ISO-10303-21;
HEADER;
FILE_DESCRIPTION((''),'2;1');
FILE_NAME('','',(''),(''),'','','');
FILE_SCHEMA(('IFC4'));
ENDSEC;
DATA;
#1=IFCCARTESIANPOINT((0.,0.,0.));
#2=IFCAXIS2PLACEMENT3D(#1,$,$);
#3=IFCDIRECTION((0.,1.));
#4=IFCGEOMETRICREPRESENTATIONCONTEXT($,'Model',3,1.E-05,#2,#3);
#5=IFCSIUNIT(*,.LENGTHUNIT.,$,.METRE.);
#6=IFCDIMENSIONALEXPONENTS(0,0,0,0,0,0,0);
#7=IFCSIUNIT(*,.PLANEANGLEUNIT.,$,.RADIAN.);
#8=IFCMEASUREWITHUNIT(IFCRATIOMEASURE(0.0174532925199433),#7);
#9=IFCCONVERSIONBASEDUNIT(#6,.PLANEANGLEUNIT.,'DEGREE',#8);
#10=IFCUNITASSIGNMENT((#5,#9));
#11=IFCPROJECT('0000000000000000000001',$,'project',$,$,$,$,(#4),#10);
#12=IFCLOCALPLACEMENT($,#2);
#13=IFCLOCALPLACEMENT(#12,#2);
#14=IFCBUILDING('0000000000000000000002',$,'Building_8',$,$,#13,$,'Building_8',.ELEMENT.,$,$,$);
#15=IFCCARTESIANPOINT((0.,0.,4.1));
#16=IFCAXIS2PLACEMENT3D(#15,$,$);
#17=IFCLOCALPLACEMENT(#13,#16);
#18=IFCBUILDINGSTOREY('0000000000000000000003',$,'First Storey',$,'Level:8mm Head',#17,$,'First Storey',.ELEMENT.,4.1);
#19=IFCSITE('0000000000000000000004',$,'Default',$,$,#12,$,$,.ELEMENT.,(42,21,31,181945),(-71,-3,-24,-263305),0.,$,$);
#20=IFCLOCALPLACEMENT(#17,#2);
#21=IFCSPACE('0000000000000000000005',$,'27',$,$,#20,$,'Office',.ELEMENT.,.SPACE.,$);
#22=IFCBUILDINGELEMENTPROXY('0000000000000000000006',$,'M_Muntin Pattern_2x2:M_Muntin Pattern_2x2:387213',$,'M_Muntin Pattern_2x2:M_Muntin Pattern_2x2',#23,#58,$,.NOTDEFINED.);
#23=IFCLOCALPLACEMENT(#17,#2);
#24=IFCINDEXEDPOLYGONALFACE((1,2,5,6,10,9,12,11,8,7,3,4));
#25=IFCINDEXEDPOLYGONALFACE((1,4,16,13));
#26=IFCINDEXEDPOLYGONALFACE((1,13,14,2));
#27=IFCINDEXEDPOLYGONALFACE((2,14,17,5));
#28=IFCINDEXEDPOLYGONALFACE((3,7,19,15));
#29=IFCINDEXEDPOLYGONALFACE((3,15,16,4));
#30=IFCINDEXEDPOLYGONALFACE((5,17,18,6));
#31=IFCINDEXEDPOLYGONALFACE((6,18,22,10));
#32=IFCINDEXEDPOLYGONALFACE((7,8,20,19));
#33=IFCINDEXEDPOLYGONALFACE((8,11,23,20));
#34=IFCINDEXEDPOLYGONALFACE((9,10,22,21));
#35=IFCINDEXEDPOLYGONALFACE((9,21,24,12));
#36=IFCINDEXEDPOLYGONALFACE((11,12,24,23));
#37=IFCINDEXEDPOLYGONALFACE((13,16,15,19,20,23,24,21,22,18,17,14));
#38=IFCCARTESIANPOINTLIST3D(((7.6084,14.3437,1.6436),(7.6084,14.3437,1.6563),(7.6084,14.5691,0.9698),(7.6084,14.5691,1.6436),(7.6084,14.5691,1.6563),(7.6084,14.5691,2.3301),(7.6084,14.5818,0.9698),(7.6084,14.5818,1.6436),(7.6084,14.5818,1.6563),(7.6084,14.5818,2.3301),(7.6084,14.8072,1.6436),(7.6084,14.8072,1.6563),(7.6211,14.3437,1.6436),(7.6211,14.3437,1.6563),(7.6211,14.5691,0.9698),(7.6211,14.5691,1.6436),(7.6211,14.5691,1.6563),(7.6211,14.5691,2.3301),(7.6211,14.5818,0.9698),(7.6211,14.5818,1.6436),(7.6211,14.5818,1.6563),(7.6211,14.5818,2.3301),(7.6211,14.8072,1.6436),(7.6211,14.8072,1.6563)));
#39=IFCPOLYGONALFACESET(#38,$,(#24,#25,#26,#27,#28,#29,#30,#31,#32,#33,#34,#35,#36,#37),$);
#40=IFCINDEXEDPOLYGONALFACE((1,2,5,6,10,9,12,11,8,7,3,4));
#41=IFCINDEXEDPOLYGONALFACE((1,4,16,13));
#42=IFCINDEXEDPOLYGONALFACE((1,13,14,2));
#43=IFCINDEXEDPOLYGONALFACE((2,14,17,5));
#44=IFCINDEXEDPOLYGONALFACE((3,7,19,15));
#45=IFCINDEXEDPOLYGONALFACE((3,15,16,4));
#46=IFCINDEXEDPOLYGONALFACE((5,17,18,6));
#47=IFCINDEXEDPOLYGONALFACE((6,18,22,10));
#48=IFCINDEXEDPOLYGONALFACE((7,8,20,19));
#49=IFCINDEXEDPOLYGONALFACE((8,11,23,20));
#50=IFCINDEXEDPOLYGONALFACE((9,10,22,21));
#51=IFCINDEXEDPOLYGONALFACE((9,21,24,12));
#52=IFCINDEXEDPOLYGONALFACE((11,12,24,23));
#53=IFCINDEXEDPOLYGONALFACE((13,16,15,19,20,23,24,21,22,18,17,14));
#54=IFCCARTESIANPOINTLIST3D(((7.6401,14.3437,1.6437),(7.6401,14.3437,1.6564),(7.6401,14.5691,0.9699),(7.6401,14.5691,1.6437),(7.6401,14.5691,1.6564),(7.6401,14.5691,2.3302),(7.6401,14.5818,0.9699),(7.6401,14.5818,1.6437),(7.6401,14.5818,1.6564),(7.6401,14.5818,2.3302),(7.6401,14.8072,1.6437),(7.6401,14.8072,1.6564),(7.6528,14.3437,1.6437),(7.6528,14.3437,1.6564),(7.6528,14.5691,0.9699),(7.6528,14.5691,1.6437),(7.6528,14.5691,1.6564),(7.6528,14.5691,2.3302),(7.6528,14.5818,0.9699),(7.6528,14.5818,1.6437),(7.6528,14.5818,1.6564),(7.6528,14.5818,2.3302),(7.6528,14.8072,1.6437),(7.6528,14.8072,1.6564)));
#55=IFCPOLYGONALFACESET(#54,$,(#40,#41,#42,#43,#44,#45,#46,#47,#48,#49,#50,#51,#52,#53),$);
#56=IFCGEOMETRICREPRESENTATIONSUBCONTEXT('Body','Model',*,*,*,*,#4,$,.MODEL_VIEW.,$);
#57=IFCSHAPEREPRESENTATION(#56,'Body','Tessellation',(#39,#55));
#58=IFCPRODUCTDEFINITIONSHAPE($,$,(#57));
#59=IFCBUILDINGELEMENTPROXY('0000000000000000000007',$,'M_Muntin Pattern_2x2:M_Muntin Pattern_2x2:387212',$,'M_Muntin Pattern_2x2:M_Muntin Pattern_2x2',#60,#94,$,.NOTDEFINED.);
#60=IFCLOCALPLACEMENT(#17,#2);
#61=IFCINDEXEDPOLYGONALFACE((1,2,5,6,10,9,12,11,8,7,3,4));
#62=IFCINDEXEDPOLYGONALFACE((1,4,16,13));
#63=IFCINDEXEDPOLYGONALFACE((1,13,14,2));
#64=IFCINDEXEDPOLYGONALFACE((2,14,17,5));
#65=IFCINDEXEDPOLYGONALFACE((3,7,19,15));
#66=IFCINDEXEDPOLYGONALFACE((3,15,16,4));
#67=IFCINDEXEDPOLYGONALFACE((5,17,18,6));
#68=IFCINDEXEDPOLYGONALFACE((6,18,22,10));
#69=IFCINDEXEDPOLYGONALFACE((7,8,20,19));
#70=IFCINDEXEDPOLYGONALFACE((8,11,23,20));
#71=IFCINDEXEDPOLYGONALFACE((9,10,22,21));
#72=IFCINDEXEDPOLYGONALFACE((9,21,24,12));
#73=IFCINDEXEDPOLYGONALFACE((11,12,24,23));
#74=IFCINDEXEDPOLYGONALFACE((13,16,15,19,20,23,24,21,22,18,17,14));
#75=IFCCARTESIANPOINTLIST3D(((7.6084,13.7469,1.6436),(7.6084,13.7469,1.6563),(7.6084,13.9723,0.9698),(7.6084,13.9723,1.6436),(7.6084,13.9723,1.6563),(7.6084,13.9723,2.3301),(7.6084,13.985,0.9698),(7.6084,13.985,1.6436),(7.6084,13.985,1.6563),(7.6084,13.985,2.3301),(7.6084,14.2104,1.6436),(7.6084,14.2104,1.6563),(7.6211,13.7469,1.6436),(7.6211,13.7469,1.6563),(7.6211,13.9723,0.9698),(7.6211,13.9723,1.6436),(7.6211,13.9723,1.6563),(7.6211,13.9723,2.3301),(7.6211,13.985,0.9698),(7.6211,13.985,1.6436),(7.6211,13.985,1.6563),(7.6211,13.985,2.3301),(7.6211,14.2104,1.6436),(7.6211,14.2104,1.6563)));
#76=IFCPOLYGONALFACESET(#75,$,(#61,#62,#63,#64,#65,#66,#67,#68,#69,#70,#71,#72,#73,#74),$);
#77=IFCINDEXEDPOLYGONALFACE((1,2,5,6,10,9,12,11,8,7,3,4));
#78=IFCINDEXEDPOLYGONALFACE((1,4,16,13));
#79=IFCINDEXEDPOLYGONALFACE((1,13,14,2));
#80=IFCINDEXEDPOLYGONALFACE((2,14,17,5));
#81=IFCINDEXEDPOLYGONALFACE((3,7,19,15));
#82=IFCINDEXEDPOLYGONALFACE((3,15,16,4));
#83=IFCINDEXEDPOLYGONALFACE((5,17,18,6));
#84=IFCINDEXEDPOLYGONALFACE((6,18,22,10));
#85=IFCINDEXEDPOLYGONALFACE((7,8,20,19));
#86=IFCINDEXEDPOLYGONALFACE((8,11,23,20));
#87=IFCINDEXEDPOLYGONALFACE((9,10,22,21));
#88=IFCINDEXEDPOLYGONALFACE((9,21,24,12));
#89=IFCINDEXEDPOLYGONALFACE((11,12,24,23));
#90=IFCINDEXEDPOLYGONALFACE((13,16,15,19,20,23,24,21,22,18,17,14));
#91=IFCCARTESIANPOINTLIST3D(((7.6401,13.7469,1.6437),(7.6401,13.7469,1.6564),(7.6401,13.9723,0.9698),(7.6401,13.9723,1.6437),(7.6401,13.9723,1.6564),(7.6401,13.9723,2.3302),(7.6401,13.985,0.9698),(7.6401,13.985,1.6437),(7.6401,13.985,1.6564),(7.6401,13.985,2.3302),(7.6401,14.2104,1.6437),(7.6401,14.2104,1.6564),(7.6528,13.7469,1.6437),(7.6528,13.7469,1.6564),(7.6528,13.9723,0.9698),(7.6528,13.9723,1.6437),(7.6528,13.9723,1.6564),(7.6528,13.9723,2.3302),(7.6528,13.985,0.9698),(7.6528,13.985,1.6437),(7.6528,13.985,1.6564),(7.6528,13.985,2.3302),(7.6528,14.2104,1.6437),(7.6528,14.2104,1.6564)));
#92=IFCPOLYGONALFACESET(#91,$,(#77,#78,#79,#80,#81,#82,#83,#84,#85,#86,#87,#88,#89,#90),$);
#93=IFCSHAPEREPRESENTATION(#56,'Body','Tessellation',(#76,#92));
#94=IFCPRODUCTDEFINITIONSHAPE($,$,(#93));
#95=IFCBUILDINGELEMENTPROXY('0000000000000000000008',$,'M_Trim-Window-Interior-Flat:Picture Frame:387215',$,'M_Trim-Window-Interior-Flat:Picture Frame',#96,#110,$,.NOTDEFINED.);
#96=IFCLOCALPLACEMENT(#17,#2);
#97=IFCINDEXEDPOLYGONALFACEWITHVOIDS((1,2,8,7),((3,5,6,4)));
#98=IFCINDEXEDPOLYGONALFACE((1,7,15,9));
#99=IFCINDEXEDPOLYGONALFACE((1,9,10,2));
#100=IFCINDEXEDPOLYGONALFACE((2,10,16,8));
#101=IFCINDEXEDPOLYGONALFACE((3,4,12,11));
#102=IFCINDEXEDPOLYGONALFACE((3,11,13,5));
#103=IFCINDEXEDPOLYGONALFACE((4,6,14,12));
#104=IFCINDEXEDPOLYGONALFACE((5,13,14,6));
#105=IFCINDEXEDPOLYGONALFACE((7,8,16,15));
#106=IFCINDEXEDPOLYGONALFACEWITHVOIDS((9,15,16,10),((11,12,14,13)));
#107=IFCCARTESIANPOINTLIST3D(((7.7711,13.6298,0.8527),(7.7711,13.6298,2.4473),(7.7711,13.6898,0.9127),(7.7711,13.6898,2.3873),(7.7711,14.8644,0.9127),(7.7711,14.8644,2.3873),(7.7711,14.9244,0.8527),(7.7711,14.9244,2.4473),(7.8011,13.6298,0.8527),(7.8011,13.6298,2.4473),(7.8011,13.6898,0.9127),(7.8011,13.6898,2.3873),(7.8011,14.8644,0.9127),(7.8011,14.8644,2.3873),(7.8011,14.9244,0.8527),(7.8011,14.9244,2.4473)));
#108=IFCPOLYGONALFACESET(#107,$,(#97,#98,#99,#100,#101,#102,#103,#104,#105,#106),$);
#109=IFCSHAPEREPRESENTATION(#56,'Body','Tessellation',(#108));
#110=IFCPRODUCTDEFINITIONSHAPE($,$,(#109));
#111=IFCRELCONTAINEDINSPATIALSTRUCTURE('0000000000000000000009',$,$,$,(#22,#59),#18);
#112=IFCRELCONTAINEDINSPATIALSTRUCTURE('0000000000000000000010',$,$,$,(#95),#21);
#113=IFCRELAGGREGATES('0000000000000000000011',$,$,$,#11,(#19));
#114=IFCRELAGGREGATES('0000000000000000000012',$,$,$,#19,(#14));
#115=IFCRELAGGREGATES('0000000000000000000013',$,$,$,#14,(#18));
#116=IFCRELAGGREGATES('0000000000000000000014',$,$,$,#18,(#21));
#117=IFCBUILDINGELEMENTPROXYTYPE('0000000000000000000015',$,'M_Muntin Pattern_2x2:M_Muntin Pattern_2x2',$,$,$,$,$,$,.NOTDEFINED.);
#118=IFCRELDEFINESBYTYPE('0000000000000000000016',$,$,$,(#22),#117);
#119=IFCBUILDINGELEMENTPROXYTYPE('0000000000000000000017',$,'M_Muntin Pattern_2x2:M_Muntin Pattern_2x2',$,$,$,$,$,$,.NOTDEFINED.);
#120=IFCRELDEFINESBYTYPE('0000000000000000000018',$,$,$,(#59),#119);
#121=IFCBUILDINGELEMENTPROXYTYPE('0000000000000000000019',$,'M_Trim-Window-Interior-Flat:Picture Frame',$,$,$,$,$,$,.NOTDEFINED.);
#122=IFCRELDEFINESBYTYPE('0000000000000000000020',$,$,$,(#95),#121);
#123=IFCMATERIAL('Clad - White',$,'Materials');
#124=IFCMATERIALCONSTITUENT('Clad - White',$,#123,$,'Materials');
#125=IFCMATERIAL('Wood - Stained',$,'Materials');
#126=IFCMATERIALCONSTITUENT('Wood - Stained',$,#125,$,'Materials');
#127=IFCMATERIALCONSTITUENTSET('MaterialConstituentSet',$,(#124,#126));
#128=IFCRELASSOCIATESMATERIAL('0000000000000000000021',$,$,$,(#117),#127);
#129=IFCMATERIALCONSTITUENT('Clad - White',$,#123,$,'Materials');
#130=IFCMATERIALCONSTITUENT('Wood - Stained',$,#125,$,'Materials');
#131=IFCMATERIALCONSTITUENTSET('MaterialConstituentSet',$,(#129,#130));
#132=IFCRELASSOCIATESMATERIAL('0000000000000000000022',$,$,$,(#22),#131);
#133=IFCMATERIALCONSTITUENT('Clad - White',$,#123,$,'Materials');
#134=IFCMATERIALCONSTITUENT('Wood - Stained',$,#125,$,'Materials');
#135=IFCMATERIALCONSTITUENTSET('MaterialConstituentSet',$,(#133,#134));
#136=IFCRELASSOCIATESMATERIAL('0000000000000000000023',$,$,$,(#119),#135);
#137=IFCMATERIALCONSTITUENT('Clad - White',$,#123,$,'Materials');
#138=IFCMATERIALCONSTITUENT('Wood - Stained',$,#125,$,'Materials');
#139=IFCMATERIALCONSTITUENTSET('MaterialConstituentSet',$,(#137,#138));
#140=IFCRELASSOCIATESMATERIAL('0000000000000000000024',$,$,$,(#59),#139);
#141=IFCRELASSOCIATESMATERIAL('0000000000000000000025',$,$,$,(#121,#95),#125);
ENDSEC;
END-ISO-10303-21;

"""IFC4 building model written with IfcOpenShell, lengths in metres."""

from ifc_helpers import new_model, entity, si_unit, converted_unit, direction, frame, origin, place, context, subcontext, project, spatial, indexed_curve, outline, extrude, source, transform, mapped, material, constituent, constituent_set, type_object, type_shapes, element, save


model = new_model("IFC4")

# Units and contexts
model_context = context("Model", 3, precision=1e-05, world=origin(), true_north=direction((0.0, 1.0)))
body_context = subcontext(model_context, "Body", "Model", "MODEL_VIEW")
ifc_project = project(units=[si_unit("LENGTHUNIT", "METRE"), converted_unit("PLANEANGLEUNIT", "DEGREE", entity("IfcRatioMeasure", 0.0174532925199433), si_unit("PLANEANGLEUNIT", "RADIAN"), dimensions=[0, 0, 0, 0, 0, 0, 0])], contexts=[model_context])

# Site, building, storey
site_placement = place(None, origin())
site = spatial("IfcSite", under=ifc_project, at=site_placement, Name="Default", CompositionType="ELEMENT", RefLatitude=(42, 21, 31, 181945), RefLongitude=(-71, -3, -24, -263305), RefElevation=0.0)
building_placement = place(site_placement, origin())
building = spatial("IfcBuilding", under=site, at=building_placement, Name="Building_8", LongName="Building_8", CompositionType="ELEMENT")
storey_placement = place(building_placement, frame((0.0, 0.0, 4.1)))
storey = spatial("IfcBuildingStorey", under=building, at=storey_placement, Name="First Storey", ObjectType="Level:8mm Head", LongName="First Storey", CompositionType="ELEMENT", Elevation=4.1)

# Shared definitions
ifc_material_1 = material(Name="Clad - White", Category="Materials")
ifc_material_2 = material(Name="Wood - Stained", Category="Materials")

# Building element proxies
ifc_constituent_1 = constituent(ifc_material_1, Name="Clad - White", Category="Materials")
ifc_constituent_2 = constituent(ifc_material_2, Name="Wood - Stained", Category="Materials")
ifc_constituent_set_1 = constituent_set(constituents=[ifc_constituent_1, ifc_constituent_2], Name="MaterialConstituentSet")
ifc_constituent_3 = constituent(ifc_material_1, Name="Clad - White", Category="Materials")
ifc_constituent_4 = constituent(ifc_material_2, Name="Wood - Stained", Category="Materials")
ifc_constituent_set_2 = constituent_set(constituents=[ifc_constituent_3, ifc_constituent_4], Name="MaterialConstituentSet")
building_element_proxy_type_1 = type_object("IfcBuildingElementProxyType", Name="M_Muntin Pattern_2x2:M_Muntin Pattern_2x2", PredefinedType="NOTDEFINED", material=ifc_constituent_set_2)
shared_shape_1 = source(origin(), body_context, "Body", "SweptSolid", [
    extrude(outline(indexed_curve([(0.0064, -0.0064), (0.6801, -0.0064), (0.6801, 0.0063), (0.0064, 0.0063), (0.0064, 0.2317), (-0.0063, 0.2317), (-0.0063, 0.0063), (-0.6802, 0.0063), (-0.6802, -0.0064), (-0.0063, -0.0064), (-0.0063, -0.2317), (0.0064, -0.2317), (0.0064, -0.0064)], self_intersect=False)), frame((0.0, -0.0222, 0.6801), z_axis=(0.0, 1.0, 0.0), x_axis=(0.0, 0.0, 1.0)), (0.0, 0.0, 1.0), 0.0127),
    extrude(outline(indexed_curve([(0.0064, -0.0064), (0.6802, -0.0064), (0.6802, 0.0063), (0.0064, 0.0063), (0.0064, 0.2317), (-0.0063, 0.2317), (-0.0063, 0.0063), (-0.6802, 0.0063), (-0.6802, -0.0064), (-0.0063, -0.0064), (-0.0063, -0.2317), (0.0064, -0.2317), (0.0064, -0.0064)], self_intersect=False)), frame((0.0, 0.0095, 0.6802), z_axis=(0.0, 1.0, 0.0), x_axis=(0.0, 0.0, 1.0)), (0.0, 0.0, 1.0), 0.0127),
])
type_shapes(building_element_proxy_type_1, [shared_shape_1])
proxy_1_placement = place(storey_placement, frame((7.6306, 14.5755, 0.9699), z_axis=(0.0, 0.0, 1.0), x_axis=(0.0, -1.0, 0.0)))
element("IfcBuildingElementProxy", 1, at=proxy_1_placement, inside=storey, type_object=building_element_proxy_type_1, material=ifc_constituent_set_1, Name="M_Muntin Pattern_2x2:M_Muntin Pattern_2x2:387213", ObjectType="M_Muntin Pattern_2x2:M_Muntin Pattern_2x2", PredefinedType="NOTDEFINED", context=body_context, shape_type="MappedRepresentation", body=[
    mapped(shared_shape_1, transform((0.0, 0.0, 0.0), scale=1.0)),
])
ifc_constituent_5 = constituent(ifc_material_1, Name="Clad - White", Category="Materials")
ifc_constituent_6 = constituent(ifc_material_2, Name="Wood - Stained", Category="Materials")
ifc_constituent_set_3 = constituent_set(constituents=[ifc_constituent_5, ifc_constituent_6], Name="MaterialConstituentSet")
ifc_constituent_7 = constituent(ifc_material_1, Name="Clad - White", Category="Materials")
ifc_constituent_8 = constituent(ifc_material_2, Name="Wood - Stained", Category="Materials")
ifc_constituent_set_4 = constituent_set(constituents=[ifc_constituent_7, ifc_constituent_8], Name="MaterialConstituentSet")
building_element_proxy_type_2 = type_object("IfcBuildingElementProxyType", Name="M_Muntin Pattern_2x2:M_Muntin Pattern_2x2", PredefinedType="NOTDEFINED", material=ifc_constituent_set_4)
shared_shape_2 = source(origin(), body_context, "Body", "SweptSolid", [
    extrude(outline(indexed_curve([(0.0064, -0.0064), (0.6801, -0.0064), (0.6801, 0.0063), (0.0064, 0.0063), (0.0064, 0.2317), (-0.0063, 0.2317), (-0.0063, 0.0063), (-0.6802, 0.0063), (-0.6802, -0.0064), (-0.0063, -0.0064), (-0.0063, -0.2317), (0.0064, -0.2317), (0.0064, -0.0064)], self_intersect=False)), frame((0.0, 0.0095, 0.6801), z_axis=(0.0, 1.0, 0.0), x_axis=(0.0, 0.0, 1.0)), (0.0, 0.0, 1.0), 0.0127),
    extrude(outline(indexed_curve([(0.0064, -0.0064), (0.6802, -0.0064), (0.6802, 0.0063), (0.0064, 0.0063), (0.0064, 0.2317), (-0.0063, 0.2317), (-0.0063, 0.0063), (-0.6802, 0.0063), (-0.6802, -0.0064), (-0.0063, -0.0064), (-0.0063, -0.2317), (0.0064, -0.2317), (0.0064, -0.0064)], self_intersect=False)), frame((0.0, -0.0222, 0.6802), z_axis=(0.0, 1.0, 0.0), x_axis=(0.0, 0.0, 1.0)), (0.0, 0.0, 1.0), 0.0127),
])
type_shapes(building_element_proxy_type_2, [shared_shape_2])
proxy_2_placement = place(storey_placement, frame((7.6306, 13.9787, 0.9698), z_axis=(0.0, 0.0, 1.0), x_axis=(0.0, 1.0, 0.0)))
element("IfcBuildingElementProxy", 2, at=proxy_2_placement, inside=storey, type_object=building_element_proxy_type_2, material=ifc_constituent_set_3, Name="M_Muntin Pattern_2x2:M_Muntin Pattern_2x2:387212", ObjectType="M_Muntin Pattern_2x2:M_Muntin Pattern_2x2", PredefinedType="NOTDEFINED", context=body_context, shape_type="MappedRepresentation", body=[
    mapped(shared_shape_2, transform((0.0, 0.0, 0.0), scale=1.0)),
])

# Shared definitions
space_1_placement = place(storey_placement, origin())
space_1 = spatial("IfcSpace", under=storey, at=space_1_placement, Name="27", LongName="Office", CompositionType="ELEMENT", PredefinedType="SPACE")

# Building element proxy
building_element_proxy_type_3 = type_object("IfcBuildingElementProxyType", Name="M_Trim-Window-Interior-Flat:Picture Frame", PredefinedType="NOTDEFINED", material=ifc_material_2)
shared_shape_3 = source(origin(), body_context, "Body", "SweptSolid", [
    extrude(outline(indexed_curve([(-0.6473, -0.7973), (0.6473, -0.7973), (0.6473, 0.7973), (-0.6473, 0.7973), (-0.6473, -0.7973)], self_intersect=False), holes=[indexed_curve([(-0.5873, -0.7373), (-0.5873, 0.7373), (0.5873, 0.7373), (0.5873, -0.7373), (-0.5873, -0.7373)], self_intersect=False)]), frame((0.0, -0.75, 0.0), z_axis=(0.0, 0.0, 1.0), x_axis=(-1.0, 0.0, 0.0)), (0.0, 0.0, 1.0), 0.03),
])
type_shapes(building_element_proxy_type_3, [shared_shape_3])
proxy_3_placement = place(space_1_placement, frame((7.7711, 14.2771, 2.4), z_axis=(1.0, 0.0, 0.0), x_axis=(0.0, 1.0, 0.0)))
element("IfcBuildingElementProxy", 3, at=proxy_3_placement, inside=space_1, type_object=building_element_proxy_type_3, material=ifc_material_2, Name="M_Trim-Window-Interior-Flat:Picture Frame:387215", ObjectType="M_Trim-Window-Interior-Flat:Picture Frame", PredefinedType="NOTDEFINED", context=body_context, shape_type="MappedRepresentation", body=[
    mapped(shared_shape_3, transform((0.0, 0.0, 0.0), scale=1.0)),
])

save(model, "model.ifc")
